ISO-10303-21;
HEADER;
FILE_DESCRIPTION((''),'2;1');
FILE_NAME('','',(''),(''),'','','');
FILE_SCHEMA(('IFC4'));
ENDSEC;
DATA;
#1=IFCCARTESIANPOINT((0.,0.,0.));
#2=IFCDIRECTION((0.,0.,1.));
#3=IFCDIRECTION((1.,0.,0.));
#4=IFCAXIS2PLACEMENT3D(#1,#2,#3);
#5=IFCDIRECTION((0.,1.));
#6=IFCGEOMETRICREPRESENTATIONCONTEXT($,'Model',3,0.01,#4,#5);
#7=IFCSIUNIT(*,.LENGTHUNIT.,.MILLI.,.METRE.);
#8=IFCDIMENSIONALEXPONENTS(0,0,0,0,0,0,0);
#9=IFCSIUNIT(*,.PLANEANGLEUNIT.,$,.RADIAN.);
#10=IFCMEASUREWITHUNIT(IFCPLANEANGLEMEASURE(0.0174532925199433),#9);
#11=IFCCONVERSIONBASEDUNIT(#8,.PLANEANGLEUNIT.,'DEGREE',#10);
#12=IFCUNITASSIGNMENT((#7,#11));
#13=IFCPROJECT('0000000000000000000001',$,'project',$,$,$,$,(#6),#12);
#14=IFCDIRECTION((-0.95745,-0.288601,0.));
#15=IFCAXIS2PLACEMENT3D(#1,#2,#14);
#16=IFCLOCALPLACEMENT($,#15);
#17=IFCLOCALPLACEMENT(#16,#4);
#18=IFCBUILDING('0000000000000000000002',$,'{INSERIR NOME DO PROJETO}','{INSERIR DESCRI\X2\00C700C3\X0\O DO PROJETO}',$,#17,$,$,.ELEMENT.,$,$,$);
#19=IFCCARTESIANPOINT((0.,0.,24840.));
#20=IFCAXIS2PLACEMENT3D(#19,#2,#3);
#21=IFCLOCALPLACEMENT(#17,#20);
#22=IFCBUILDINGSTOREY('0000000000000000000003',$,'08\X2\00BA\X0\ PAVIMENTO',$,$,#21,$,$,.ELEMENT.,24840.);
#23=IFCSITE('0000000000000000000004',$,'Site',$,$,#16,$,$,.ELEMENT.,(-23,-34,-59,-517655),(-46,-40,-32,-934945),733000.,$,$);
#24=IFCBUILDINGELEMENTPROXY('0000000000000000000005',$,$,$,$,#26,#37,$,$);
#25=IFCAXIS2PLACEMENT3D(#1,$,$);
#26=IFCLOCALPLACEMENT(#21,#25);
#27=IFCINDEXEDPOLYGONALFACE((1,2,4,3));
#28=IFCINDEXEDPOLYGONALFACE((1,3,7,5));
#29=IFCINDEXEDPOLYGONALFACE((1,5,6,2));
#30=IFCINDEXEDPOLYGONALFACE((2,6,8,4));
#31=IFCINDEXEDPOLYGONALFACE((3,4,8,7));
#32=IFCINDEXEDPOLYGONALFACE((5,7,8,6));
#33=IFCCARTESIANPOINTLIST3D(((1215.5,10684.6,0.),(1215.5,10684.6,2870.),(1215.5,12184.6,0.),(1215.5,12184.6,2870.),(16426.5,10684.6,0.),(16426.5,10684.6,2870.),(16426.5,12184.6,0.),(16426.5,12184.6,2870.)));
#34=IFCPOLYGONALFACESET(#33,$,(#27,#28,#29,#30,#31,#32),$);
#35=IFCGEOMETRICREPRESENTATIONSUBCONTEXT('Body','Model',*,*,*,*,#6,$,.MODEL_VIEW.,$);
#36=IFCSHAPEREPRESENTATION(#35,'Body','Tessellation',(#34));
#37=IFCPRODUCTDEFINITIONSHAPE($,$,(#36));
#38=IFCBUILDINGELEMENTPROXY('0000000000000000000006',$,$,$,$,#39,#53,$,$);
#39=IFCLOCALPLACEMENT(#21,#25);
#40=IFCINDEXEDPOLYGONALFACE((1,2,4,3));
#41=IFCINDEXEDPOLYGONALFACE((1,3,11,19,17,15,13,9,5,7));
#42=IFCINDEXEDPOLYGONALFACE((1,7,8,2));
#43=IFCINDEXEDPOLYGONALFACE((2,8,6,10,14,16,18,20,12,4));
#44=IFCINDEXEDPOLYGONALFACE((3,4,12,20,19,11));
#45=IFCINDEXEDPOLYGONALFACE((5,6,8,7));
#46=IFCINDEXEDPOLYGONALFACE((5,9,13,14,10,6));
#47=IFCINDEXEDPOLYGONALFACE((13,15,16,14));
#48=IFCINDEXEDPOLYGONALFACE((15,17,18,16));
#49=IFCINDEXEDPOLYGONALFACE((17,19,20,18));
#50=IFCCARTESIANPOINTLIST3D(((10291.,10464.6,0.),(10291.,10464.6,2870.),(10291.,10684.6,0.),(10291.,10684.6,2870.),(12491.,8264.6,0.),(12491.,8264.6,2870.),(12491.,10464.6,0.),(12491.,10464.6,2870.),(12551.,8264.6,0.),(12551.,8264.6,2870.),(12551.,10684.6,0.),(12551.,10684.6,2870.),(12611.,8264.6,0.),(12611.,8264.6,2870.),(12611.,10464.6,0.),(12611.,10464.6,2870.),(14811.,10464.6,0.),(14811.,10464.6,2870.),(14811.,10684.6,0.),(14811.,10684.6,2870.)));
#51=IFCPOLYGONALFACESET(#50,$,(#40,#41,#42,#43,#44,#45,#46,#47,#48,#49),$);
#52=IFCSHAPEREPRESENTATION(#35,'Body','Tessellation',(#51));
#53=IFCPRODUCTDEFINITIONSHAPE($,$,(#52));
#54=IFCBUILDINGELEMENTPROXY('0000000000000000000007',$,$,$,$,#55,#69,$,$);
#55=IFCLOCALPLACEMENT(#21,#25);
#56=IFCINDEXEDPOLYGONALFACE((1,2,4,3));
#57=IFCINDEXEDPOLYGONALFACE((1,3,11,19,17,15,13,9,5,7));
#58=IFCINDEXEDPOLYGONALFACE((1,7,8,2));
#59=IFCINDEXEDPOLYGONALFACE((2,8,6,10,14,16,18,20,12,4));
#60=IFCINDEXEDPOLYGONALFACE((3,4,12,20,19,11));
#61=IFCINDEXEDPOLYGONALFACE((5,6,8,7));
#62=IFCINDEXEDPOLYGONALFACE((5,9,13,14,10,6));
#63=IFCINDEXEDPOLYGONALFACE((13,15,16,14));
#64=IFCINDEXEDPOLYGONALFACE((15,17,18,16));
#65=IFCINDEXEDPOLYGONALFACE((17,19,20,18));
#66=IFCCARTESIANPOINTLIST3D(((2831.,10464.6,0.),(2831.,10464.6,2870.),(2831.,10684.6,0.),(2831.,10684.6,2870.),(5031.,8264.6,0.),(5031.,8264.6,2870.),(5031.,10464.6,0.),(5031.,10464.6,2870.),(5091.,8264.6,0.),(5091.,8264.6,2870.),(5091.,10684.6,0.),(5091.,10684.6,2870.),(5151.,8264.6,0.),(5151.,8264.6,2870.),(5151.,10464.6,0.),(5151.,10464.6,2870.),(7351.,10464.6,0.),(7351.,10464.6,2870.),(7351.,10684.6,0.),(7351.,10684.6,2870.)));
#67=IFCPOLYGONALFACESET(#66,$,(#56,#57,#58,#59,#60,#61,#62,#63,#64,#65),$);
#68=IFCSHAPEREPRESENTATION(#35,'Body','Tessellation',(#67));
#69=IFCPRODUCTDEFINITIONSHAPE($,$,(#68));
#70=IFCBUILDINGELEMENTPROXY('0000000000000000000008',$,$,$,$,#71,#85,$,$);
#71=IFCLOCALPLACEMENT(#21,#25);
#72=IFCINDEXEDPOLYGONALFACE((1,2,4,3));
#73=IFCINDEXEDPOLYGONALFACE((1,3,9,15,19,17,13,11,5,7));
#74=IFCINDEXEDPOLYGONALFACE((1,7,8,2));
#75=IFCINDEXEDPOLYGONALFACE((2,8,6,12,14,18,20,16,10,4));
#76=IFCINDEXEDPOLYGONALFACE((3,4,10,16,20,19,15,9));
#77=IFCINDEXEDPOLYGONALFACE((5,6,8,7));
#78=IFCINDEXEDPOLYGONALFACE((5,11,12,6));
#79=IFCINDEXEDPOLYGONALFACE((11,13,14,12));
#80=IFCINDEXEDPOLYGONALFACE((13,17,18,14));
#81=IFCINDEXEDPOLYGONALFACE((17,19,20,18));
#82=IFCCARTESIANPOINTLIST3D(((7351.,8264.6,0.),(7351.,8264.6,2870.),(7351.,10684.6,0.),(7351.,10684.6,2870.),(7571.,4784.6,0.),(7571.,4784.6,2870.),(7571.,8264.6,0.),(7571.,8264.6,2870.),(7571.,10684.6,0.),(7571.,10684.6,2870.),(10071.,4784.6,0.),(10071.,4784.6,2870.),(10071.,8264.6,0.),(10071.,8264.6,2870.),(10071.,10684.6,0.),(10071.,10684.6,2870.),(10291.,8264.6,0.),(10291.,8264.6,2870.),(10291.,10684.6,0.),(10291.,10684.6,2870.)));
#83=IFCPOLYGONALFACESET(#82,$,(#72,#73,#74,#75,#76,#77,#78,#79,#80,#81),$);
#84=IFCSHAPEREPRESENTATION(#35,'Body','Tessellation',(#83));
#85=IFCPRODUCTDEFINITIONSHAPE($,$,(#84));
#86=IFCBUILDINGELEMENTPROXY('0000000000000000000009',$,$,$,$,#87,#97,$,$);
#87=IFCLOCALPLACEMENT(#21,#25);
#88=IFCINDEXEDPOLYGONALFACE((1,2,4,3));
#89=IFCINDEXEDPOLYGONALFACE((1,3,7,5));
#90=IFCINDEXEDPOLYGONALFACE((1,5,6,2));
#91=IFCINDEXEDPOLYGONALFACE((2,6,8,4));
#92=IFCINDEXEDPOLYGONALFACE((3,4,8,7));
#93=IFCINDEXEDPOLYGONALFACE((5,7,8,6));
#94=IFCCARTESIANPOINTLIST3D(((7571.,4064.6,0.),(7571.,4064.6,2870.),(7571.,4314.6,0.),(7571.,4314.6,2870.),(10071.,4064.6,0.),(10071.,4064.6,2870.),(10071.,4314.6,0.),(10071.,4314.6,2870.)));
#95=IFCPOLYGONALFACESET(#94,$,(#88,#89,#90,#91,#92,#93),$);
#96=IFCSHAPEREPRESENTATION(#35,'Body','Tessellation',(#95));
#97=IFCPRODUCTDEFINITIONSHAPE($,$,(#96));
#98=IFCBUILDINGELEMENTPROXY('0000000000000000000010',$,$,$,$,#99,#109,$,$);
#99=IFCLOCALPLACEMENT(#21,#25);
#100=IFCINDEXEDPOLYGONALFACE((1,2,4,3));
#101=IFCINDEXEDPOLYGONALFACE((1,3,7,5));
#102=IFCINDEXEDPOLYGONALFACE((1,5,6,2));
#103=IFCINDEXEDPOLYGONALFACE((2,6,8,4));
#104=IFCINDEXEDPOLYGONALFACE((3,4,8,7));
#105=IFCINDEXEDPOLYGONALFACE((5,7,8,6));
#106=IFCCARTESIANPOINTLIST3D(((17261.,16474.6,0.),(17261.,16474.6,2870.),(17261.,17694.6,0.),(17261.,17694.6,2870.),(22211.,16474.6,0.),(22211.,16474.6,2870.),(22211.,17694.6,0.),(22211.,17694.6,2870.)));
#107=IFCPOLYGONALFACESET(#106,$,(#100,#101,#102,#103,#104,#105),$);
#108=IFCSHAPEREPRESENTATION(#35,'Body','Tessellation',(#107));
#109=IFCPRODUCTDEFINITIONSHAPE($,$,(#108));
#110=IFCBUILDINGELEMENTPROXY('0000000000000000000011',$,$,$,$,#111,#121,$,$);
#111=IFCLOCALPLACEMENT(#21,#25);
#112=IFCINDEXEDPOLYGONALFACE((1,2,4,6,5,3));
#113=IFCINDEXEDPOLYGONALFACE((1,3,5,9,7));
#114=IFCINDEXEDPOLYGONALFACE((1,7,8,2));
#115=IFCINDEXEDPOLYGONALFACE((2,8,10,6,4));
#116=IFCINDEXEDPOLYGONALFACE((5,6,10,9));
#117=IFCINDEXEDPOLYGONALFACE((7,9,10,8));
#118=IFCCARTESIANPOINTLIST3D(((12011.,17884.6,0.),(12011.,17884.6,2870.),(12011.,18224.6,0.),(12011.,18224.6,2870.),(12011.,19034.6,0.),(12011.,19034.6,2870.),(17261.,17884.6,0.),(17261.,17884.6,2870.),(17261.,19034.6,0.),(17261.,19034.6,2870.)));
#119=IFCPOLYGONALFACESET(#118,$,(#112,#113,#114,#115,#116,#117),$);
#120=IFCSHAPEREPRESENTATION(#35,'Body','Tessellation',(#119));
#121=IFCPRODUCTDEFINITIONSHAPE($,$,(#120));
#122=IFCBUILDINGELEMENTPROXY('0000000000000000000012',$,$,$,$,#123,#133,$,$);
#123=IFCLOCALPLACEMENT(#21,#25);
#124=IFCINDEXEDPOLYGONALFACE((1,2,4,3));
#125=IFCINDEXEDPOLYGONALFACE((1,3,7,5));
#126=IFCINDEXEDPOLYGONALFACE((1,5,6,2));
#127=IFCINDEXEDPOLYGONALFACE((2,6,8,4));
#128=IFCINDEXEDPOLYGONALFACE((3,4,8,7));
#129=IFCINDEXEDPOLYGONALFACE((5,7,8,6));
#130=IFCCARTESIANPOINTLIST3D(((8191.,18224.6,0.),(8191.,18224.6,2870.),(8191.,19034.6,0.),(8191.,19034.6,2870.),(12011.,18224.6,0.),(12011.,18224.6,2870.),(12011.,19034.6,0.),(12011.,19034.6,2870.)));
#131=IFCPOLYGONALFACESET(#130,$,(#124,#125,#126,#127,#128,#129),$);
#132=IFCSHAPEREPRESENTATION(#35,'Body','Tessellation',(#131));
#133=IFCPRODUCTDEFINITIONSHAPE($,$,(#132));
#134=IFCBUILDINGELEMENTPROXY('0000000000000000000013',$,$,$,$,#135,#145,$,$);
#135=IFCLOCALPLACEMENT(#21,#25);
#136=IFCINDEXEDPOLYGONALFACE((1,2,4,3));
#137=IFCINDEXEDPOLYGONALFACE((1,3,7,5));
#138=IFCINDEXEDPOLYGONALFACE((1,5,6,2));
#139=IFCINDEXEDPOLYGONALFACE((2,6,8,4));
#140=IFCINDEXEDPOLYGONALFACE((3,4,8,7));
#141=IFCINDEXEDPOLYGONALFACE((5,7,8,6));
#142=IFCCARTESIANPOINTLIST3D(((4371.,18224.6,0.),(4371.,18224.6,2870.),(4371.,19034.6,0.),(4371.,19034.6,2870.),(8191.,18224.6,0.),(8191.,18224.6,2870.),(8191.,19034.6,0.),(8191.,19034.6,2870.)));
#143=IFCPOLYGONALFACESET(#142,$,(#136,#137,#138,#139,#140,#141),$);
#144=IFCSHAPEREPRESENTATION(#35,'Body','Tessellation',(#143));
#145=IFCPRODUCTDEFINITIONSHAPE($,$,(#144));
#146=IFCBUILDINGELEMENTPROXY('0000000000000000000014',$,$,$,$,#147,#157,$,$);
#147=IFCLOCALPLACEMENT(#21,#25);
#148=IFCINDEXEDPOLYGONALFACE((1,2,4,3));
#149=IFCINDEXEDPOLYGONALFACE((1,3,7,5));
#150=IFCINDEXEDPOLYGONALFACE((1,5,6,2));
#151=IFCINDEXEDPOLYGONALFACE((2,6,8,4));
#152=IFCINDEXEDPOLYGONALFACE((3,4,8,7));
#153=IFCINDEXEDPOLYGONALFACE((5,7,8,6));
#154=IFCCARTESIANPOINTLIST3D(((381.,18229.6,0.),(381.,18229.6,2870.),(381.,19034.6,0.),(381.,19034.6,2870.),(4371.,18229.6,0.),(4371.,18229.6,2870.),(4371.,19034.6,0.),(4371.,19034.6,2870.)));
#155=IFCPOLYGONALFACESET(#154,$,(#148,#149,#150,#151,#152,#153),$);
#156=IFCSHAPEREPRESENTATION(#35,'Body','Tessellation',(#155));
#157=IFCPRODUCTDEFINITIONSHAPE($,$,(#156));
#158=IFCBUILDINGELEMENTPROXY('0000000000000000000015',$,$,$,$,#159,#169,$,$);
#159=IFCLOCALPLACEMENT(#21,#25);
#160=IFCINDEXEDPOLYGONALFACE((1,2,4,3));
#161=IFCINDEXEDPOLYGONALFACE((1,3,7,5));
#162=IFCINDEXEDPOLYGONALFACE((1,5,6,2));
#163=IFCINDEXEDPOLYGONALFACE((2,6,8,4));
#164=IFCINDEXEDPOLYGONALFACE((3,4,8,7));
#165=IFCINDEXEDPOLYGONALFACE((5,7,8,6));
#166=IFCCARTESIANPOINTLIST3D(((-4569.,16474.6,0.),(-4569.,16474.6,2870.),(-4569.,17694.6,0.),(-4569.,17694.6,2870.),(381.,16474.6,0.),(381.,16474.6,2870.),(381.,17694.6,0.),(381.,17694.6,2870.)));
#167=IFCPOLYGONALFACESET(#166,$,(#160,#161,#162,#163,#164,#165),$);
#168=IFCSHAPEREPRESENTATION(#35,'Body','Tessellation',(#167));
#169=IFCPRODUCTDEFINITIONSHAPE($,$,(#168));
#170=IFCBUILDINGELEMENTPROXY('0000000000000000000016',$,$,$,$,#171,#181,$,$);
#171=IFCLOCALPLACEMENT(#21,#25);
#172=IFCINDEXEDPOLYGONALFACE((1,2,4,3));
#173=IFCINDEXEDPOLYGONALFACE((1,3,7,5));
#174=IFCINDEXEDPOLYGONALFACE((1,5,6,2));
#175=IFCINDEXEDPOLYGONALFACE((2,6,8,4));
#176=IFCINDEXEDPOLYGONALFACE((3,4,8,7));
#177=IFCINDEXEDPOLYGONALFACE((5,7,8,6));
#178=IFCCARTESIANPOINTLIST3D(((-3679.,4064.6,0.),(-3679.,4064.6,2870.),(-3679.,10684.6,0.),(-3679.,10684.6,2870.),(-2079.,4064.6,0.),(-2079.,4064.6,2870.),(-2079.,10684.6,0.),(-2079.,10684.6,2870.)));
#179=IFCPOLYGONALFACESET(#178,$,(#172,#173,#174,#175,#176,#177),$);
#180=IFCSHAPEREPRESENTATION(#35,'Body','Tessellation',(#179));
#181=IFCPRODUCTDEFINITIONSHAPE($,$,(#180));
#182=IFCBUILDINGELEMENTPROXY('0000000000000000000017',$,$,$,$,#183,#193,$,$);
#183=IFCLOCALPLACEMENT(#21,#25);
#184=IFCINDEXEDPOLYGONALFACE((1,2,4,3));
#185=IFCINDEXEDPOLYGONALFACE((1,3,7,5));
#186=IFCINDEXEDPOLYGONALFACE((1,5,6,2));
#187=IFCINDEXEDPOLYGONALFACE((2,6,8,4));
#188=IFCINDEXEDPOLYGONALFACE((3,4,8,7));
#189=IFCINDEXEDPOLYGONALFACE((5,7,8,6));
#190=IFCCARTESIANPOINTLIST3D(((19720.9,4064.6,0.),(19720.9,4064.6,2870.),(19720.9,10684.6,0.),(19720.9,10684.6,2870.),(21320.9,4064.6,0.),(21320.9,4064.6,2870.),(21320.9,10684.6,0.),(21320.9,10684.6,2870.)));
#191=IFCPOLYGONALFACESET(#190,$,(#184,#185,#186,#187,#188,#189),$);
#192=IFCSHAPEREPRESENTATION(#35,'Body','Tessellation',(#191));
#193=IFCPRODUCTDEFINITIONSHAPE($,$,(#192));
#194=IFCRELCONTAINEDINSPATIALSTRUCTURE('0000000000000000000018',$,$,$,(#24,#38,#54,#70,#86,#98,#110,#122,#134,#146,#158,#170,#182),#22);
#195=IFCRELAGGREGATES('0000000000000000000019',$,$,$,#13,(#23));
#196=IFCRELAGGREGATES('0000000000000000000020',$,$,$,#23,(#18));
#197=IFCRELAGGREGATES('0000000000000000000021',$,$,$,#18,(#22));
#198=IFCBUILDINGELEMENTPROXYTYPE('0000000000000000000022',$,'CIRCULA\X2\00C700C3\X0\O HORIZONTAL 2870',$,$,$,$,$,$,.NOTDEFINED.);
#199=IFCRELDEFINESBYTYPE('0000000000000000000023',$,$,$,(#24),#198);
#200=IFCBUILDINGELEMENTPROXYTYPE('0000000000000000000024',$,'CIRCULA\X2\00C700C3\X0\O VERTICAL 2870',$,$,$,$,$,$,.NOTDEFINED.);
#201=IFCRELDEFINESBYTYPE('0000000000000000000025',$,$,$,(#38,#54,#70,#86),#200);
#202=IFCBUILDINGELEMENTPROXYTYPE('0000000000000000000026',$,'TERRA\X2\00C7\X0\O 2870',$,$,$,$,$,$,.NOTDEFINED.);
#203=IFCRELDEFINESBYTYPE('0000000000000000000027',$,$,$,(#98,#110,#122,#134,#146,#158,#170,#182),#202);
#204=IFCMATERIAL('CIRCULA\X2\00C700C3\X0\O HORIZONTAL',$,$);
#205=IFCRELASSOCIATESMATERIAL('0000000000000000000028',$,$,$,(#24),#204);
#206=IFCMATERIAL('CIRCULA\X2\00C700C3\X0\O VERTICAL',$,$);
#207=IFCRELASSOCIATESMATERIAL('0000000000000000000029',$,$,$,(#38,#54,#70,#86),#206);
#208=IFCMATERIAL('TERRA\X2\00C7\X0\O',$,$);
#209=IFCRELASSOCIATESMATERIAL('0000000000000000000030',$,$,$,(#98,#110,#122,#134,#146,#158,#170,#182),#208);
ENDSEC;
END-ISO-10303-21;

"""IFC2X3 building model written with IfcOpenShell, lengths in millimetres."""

from ifc_helpers import new_model, entity, si_unit, converted_unit, direction, frame, origin_with_axes, place, context, subcontext, project, spatial, polyline, outline, extrude, material, type_object, element, save


model = new_model("IFC2X3")

# Units and contexts
model_context = context("Model", 3, precision=0.01, world=origin_with_axes(), true_north=direction((0.0, 1.0)))
body_context = subcontext(model_context, "Body", "Model", "MODEL_VIEW")
ifc_project = project(units=[si_unit("LENGTHUNIT", "METRE", prefix="MILLI"), converted_unit("PLANEANGLEUNIT", "DEGREE", entity("IfcPlaneAngleMeasure", 0.0174532925199433), si_unit("PLANEANGLEUNIT", "RADIAN"), dimensions=[0, 0, 0, 0, 0, 0, 0])], contexts=[model_context])

# Site, building, storey
site_placement = place(None, frame((0.0, 0.0, 0.0), z_axis=(0.0, 0.0, 1.0), x_axis=(-0.95745, -0.288601, 0.0)))
site = spatial("IfcSite", under=ifc_project, at=site_placement, Name="Site", CompositionType="ELEMENT", RefLatitude=(-23, -34, -59, -517655), RefLongitude=(-46, -40, -32, -934945), RefElevation=733000.0)
building_placement = place(site_placement, origin_with_axes())
building = spatial("IfcBuilding", under=site, at=building_placement, Name="{INSERIR NOME DO PROJETO}", Description="{INSERIR DESCRIÇÃO DO PROJETO}", CompositionType="ELEMENT")
storey_placement = place(building_placement, frame((0.0, 0.0, 24840.0), z_axis=(0.0, 0.0, 1.0), x_axis=(1.0, 0.0, 0.0)))
storey = spatial("IfcBuildingStorey", under=building, at=storey_placement, Name="08º PAVIMENTO", CompositionType="ELEMENT", Elevation=24840.0)

# Building element proxies
ifc_material_1 = material(Name="CIRCULAÇÃO HORIZONTAL")
building_element_proxy_type_1 = type_object("IfcBuildingElementProxyType", Name="CIRCULAÇÃO HORIZONTAL 2870", PredefinedType="NOTDEFINED")
proxy_1_placement = place(storey_placement, frame((1215.5, 10684.6, 0.0), z_axis=(0.0, 0.0, 1.0), x_axis=(1.0, 0.0, 0.0)))
element("IfcBuildingElementProxy", 1, at=proxy_1_placement, inside=storey, type_object=building_element_proxy_type_1, material=ifc_material_1, context=body_context, shape_type="SweptSolid", body=[
    extrude(outline(polyline([(0.0, 0.0), (15211.0, 0.0), (15211.0, 1500.0), (0.0, 1500.0), (0.0, 0.0)])), origin_with_axes(), (0.0, 0.0, 1.0), 2870.0),
])
ifc_material_2 = material(Name="CIRCULAÇÃO VERTICAL")
building_element_proxy_type_2 = type_object("IfcBuildingElementProxyType", Name="CIRCULAÇÃO VERTICAL 2870", PredefinedType="NOTDEFINED")
proxy_2_placement = place(storey_placement, frame((10291.0, 10684.6, 0.0), z_axis=(0.0, 0.0, 1.0), x_axis=(1.0, 0.0, 0.0)))
element("IfcBuildingElementProxy", 2, at=proxy_2_placement, inside=storey, type_object=building_element_proxy_type_2, material=ifc_material_2, context=body_context, shape_type="SweptSolid", body=[
    extrude(outline(polyline([(0.0, 0.0), (0.0, -220.0), (2200.0, -220.0), (2200.0, -2420.0), (2260.0, -2420.0), (2320.0, -2420.0), (2320.0, -220.0), (4520.0, -220.0), (4520.0, 0.0), (2260.0, 0.0), (0.0, 0.0)])), origin_with_axes(), (0.0, 0.0, 1.0), 2870.0),
])
proxy_3_placement = place(storey_placement, frame((5091.0, 10684.6, 0.0), z_axis=(0.0, 0.0, 1.0), x_axis=(1.0, 0.0, 0.0)))
element("IfcBuildingElementProxy", 3, at=proxy_3_placement, inside=storey, type_object=building_element_proxy_type_2, material=ifc_material_2, context=body_context, shape_type="SweptSolid", body=[
    extrude(outline(polyline([(0.0, 0.0), (-2260.0, 0.0), (-2260.0, -220.0), (-60.0, -220.0), (-60.0, -2420.0), (0.0, -2420.0), (60.0, -2420.0), (60.0, -220.0), (2260.0, -220.0), (2260.0, 0.0), (0.0, 0.0)])), origin_with_axes(), (0.0, 0.0, 1.0), 2870.0),
])
proxy_4_placement = place(storey_placement, frame((7351.0, 10684.6, 0.0), z_axis=(0.0, 0.0, 1.0), x_axis=(1.0, 0.0, 0.0)))
element("IfcBuildingElementProxy", 4, at=proxy_4_placement, inside=storey, type_object=building_element_proxy_type_2, material=ifc_material_2, context=body_context, shape_type="SweptSolid", body=[
    extrude(outline(polyline([(0.0, 0.0), (0.0, -2420.0), (220.0, -2420.0), (220.0, -5900.0), (2720.0, -5900.0), (2720.0, -2420.0), (2940.0, -2420.0), (2940.0, 0.0), (2720.0, 0.0), (220.0, 0.0), (0.0, 0.0)])), origin_with_axes(), (0.0, 0.0, 1.0), 2870.0),
])
proxy_5_placement = place(storey_placement, frame((7571.0, 4064.6, 0.0), z_axis=(0.0, 0.0, 1.0), x_axis=(1.0, 0.0, 0.0)))
element("IfcBuildingElementProxy", 5, at=proxy_5_placement, inside=storey, type_object=building_element_proxy_type_2, material=ifc_material_2, context=body_context, shape_type="SweptSolid", body=[
    extrude(outline(polyline([(0.0, 0.0), (2500.0, 0.0), (2500.0, 250.0), (0.0, 250.0), (0.0, 0.0)])), origin_with_axes(), (0.0, 0.0, 1.0), 2870.0),
])
ifc_material_3 = material(Name="TERRAÇO")
building_element_proxy_type_3 = type_object("IfcBuildingElementProxyType", Name="TERRAÇO 2870", PredefinedType="NOTDEFINED")
proxy_6_placement = place(storey_placement, frame((17261.0, 16474.6, 0.0), z_axis=(0.0, 0.0, 1.0), x_axis=(1.0, 0.0, 0.0)))
element("IfcBuildingElementProxy", 6, at=proxy_6_placement, inside=storey, type_object=building_element_proxy_type_3, material=ifc_material_3, context=body_context, shape_type="SweptSolid", body=[
    extrude(outline(polyline([(0.0, 0.0), (4950.0, 0.0), (4950.0, 1220.0), (0.0, 1220.0), (0.0, 0.0)])), origin_with_axes(), (0.0, 0.0, 1.0), 2870.0),
])
proxy_7_placement = place(storey_placement, frame((12011.0, 19034.6, 0.0), z_axis=(0.0, 0.0, 1.0), x_axis=(1.0, 0.0, 0.0)))
element("IfcBuildingElementProxy", 7, at=proxy_7_placement, inside=storey, type_object=building_element_proxy_type_3, material=ifc_material_3, context=body_context, shape_type="SweptSolid", body=[
    extrude(outline(polyline([(0.0, 0.0), (0.0, -810.0), (0.0, -1150.0), (5250.0, -1150.0), (5250.0, 0.0), (0.0, 0.0)])), origin_with_axes(), (0.0, 0.0, 1.0), 2870.0),
])
for number, where, z_axis, x_axis in (
    (8, (8191.0, 18224.6, 0.0), (0.0, 0.0, 1.0), (1.0, 0.0, 0.0)),
    (9, (4371.0, 18224.6, 0.0), (0.0, 0.0, 1.0), (1.0, 0.0, 0.0)),
):
    element("IfcBuildingElementProxy", number, at=place(storey_placement, frame(where, z_axis=z_axis, x_axis=x_axis)), inside=storey, type_object=building_element_proxy_type_3, material=ifc_material_3, context=body_context, shape_type="SweptSolid", body=[
        extrude(outline(polyline([(0.0, 0.0), (3820.0, 0.0), (3820.0, 810.0), (0.0, 810.0), (0.0, 0.0)])), origin_with_axes(), (0.0, 0.0, 1.0), 2870.0),
    ])
proxy_8_placement = place(storey_placement, frame((381.0, 19034.6, 0.0), z_axis=(0.0, 0.0, 1.0), x_axis=(1.0, 0.0, 0.0)))
element("IfcBuildingElementProxy", 10, at=proxy_8_placement, inside=storey, type_object=building_element_proxy_type_3, material=ifc_material_3, context=body_context, shape_type="SweptSolid", body=[
    extrude(outline(polyline([(0.0, 0.0), (0.0, -805.0), (3990.0, -805.0), (3990.0, 0.0), (0.0, 0.0)])), origin_with_axes(), (0.0, 0.0, 1.0), 2870.0),
])
proxy_9_placement = place(storey_placement, frame((381.0, 17694.6, 0.0), z_axis=(0.0, 0.0, 1.0), x_axis=(1.0, 0.0, 0.0)))
element("IfcBuildingElementProxy", 11, at=proxy_9_placement, inside=storey, type_object=building_element_proxy_type_3, material=ifc_material_3, context=body_context, shape_type="SweptSolid", body=[
    extrude(outline(polyline([(0.0, 0.0), (-4950.0, 0.0), (-4950.0, -1220.0), (0.0, -1220.0), (0.0, 0.0)])), origin_with_axes(), (0.0, 0.0, 1.0), 2870.0),
])
proxy_10_placement = place(storey_placement, frame((-3679.0, 4064.6, 0.0), z_axis=(0.0, 0.0, 1.0), x_axis=(1.0, 0.0, 0.0)))
element("IfcBuildingElementProxy", 12, at=proxy_10_placement, inside=storey, type_object=building_element_proxy_type_3, material=ifc_material_3, context=body_context, shape_type="SweptSolid", body=[
    extrude(outline(polyline([(0.0, 0.0), (1600.0, 0.0), (1600.0, 6620.0), (0.0, 6620.0), (0.0, 0.0)])), origin_with_axes(), (0.0, 0.0, 1.0), 2870.0),
])
proxy_11_placement = place(storey_placement, frame((21320.9, 4064.6, 0.0), z_axis=(0.0, 0.0, 1.0), x_axis=(1.0, 0.0, 0.0)))
element("IfcBuildingElementProxy", 13, at=proxy_11_placement, inside=storey, type_object=building_element_proxy_type_3, material=ifc_material_3, context=body_context, shape_type="SweptSolid", body=[
    extrude(outline(polyline([(0.0, 0.0), (0.0, 6620.0), (-1600.0, 6620.0), (-1600.0, 0.0), (0.0, 0.0)])), origin_with_axes(), (0.0, 0.0, 1.0), 2870.0),
])

save(model, "model.ifc")
